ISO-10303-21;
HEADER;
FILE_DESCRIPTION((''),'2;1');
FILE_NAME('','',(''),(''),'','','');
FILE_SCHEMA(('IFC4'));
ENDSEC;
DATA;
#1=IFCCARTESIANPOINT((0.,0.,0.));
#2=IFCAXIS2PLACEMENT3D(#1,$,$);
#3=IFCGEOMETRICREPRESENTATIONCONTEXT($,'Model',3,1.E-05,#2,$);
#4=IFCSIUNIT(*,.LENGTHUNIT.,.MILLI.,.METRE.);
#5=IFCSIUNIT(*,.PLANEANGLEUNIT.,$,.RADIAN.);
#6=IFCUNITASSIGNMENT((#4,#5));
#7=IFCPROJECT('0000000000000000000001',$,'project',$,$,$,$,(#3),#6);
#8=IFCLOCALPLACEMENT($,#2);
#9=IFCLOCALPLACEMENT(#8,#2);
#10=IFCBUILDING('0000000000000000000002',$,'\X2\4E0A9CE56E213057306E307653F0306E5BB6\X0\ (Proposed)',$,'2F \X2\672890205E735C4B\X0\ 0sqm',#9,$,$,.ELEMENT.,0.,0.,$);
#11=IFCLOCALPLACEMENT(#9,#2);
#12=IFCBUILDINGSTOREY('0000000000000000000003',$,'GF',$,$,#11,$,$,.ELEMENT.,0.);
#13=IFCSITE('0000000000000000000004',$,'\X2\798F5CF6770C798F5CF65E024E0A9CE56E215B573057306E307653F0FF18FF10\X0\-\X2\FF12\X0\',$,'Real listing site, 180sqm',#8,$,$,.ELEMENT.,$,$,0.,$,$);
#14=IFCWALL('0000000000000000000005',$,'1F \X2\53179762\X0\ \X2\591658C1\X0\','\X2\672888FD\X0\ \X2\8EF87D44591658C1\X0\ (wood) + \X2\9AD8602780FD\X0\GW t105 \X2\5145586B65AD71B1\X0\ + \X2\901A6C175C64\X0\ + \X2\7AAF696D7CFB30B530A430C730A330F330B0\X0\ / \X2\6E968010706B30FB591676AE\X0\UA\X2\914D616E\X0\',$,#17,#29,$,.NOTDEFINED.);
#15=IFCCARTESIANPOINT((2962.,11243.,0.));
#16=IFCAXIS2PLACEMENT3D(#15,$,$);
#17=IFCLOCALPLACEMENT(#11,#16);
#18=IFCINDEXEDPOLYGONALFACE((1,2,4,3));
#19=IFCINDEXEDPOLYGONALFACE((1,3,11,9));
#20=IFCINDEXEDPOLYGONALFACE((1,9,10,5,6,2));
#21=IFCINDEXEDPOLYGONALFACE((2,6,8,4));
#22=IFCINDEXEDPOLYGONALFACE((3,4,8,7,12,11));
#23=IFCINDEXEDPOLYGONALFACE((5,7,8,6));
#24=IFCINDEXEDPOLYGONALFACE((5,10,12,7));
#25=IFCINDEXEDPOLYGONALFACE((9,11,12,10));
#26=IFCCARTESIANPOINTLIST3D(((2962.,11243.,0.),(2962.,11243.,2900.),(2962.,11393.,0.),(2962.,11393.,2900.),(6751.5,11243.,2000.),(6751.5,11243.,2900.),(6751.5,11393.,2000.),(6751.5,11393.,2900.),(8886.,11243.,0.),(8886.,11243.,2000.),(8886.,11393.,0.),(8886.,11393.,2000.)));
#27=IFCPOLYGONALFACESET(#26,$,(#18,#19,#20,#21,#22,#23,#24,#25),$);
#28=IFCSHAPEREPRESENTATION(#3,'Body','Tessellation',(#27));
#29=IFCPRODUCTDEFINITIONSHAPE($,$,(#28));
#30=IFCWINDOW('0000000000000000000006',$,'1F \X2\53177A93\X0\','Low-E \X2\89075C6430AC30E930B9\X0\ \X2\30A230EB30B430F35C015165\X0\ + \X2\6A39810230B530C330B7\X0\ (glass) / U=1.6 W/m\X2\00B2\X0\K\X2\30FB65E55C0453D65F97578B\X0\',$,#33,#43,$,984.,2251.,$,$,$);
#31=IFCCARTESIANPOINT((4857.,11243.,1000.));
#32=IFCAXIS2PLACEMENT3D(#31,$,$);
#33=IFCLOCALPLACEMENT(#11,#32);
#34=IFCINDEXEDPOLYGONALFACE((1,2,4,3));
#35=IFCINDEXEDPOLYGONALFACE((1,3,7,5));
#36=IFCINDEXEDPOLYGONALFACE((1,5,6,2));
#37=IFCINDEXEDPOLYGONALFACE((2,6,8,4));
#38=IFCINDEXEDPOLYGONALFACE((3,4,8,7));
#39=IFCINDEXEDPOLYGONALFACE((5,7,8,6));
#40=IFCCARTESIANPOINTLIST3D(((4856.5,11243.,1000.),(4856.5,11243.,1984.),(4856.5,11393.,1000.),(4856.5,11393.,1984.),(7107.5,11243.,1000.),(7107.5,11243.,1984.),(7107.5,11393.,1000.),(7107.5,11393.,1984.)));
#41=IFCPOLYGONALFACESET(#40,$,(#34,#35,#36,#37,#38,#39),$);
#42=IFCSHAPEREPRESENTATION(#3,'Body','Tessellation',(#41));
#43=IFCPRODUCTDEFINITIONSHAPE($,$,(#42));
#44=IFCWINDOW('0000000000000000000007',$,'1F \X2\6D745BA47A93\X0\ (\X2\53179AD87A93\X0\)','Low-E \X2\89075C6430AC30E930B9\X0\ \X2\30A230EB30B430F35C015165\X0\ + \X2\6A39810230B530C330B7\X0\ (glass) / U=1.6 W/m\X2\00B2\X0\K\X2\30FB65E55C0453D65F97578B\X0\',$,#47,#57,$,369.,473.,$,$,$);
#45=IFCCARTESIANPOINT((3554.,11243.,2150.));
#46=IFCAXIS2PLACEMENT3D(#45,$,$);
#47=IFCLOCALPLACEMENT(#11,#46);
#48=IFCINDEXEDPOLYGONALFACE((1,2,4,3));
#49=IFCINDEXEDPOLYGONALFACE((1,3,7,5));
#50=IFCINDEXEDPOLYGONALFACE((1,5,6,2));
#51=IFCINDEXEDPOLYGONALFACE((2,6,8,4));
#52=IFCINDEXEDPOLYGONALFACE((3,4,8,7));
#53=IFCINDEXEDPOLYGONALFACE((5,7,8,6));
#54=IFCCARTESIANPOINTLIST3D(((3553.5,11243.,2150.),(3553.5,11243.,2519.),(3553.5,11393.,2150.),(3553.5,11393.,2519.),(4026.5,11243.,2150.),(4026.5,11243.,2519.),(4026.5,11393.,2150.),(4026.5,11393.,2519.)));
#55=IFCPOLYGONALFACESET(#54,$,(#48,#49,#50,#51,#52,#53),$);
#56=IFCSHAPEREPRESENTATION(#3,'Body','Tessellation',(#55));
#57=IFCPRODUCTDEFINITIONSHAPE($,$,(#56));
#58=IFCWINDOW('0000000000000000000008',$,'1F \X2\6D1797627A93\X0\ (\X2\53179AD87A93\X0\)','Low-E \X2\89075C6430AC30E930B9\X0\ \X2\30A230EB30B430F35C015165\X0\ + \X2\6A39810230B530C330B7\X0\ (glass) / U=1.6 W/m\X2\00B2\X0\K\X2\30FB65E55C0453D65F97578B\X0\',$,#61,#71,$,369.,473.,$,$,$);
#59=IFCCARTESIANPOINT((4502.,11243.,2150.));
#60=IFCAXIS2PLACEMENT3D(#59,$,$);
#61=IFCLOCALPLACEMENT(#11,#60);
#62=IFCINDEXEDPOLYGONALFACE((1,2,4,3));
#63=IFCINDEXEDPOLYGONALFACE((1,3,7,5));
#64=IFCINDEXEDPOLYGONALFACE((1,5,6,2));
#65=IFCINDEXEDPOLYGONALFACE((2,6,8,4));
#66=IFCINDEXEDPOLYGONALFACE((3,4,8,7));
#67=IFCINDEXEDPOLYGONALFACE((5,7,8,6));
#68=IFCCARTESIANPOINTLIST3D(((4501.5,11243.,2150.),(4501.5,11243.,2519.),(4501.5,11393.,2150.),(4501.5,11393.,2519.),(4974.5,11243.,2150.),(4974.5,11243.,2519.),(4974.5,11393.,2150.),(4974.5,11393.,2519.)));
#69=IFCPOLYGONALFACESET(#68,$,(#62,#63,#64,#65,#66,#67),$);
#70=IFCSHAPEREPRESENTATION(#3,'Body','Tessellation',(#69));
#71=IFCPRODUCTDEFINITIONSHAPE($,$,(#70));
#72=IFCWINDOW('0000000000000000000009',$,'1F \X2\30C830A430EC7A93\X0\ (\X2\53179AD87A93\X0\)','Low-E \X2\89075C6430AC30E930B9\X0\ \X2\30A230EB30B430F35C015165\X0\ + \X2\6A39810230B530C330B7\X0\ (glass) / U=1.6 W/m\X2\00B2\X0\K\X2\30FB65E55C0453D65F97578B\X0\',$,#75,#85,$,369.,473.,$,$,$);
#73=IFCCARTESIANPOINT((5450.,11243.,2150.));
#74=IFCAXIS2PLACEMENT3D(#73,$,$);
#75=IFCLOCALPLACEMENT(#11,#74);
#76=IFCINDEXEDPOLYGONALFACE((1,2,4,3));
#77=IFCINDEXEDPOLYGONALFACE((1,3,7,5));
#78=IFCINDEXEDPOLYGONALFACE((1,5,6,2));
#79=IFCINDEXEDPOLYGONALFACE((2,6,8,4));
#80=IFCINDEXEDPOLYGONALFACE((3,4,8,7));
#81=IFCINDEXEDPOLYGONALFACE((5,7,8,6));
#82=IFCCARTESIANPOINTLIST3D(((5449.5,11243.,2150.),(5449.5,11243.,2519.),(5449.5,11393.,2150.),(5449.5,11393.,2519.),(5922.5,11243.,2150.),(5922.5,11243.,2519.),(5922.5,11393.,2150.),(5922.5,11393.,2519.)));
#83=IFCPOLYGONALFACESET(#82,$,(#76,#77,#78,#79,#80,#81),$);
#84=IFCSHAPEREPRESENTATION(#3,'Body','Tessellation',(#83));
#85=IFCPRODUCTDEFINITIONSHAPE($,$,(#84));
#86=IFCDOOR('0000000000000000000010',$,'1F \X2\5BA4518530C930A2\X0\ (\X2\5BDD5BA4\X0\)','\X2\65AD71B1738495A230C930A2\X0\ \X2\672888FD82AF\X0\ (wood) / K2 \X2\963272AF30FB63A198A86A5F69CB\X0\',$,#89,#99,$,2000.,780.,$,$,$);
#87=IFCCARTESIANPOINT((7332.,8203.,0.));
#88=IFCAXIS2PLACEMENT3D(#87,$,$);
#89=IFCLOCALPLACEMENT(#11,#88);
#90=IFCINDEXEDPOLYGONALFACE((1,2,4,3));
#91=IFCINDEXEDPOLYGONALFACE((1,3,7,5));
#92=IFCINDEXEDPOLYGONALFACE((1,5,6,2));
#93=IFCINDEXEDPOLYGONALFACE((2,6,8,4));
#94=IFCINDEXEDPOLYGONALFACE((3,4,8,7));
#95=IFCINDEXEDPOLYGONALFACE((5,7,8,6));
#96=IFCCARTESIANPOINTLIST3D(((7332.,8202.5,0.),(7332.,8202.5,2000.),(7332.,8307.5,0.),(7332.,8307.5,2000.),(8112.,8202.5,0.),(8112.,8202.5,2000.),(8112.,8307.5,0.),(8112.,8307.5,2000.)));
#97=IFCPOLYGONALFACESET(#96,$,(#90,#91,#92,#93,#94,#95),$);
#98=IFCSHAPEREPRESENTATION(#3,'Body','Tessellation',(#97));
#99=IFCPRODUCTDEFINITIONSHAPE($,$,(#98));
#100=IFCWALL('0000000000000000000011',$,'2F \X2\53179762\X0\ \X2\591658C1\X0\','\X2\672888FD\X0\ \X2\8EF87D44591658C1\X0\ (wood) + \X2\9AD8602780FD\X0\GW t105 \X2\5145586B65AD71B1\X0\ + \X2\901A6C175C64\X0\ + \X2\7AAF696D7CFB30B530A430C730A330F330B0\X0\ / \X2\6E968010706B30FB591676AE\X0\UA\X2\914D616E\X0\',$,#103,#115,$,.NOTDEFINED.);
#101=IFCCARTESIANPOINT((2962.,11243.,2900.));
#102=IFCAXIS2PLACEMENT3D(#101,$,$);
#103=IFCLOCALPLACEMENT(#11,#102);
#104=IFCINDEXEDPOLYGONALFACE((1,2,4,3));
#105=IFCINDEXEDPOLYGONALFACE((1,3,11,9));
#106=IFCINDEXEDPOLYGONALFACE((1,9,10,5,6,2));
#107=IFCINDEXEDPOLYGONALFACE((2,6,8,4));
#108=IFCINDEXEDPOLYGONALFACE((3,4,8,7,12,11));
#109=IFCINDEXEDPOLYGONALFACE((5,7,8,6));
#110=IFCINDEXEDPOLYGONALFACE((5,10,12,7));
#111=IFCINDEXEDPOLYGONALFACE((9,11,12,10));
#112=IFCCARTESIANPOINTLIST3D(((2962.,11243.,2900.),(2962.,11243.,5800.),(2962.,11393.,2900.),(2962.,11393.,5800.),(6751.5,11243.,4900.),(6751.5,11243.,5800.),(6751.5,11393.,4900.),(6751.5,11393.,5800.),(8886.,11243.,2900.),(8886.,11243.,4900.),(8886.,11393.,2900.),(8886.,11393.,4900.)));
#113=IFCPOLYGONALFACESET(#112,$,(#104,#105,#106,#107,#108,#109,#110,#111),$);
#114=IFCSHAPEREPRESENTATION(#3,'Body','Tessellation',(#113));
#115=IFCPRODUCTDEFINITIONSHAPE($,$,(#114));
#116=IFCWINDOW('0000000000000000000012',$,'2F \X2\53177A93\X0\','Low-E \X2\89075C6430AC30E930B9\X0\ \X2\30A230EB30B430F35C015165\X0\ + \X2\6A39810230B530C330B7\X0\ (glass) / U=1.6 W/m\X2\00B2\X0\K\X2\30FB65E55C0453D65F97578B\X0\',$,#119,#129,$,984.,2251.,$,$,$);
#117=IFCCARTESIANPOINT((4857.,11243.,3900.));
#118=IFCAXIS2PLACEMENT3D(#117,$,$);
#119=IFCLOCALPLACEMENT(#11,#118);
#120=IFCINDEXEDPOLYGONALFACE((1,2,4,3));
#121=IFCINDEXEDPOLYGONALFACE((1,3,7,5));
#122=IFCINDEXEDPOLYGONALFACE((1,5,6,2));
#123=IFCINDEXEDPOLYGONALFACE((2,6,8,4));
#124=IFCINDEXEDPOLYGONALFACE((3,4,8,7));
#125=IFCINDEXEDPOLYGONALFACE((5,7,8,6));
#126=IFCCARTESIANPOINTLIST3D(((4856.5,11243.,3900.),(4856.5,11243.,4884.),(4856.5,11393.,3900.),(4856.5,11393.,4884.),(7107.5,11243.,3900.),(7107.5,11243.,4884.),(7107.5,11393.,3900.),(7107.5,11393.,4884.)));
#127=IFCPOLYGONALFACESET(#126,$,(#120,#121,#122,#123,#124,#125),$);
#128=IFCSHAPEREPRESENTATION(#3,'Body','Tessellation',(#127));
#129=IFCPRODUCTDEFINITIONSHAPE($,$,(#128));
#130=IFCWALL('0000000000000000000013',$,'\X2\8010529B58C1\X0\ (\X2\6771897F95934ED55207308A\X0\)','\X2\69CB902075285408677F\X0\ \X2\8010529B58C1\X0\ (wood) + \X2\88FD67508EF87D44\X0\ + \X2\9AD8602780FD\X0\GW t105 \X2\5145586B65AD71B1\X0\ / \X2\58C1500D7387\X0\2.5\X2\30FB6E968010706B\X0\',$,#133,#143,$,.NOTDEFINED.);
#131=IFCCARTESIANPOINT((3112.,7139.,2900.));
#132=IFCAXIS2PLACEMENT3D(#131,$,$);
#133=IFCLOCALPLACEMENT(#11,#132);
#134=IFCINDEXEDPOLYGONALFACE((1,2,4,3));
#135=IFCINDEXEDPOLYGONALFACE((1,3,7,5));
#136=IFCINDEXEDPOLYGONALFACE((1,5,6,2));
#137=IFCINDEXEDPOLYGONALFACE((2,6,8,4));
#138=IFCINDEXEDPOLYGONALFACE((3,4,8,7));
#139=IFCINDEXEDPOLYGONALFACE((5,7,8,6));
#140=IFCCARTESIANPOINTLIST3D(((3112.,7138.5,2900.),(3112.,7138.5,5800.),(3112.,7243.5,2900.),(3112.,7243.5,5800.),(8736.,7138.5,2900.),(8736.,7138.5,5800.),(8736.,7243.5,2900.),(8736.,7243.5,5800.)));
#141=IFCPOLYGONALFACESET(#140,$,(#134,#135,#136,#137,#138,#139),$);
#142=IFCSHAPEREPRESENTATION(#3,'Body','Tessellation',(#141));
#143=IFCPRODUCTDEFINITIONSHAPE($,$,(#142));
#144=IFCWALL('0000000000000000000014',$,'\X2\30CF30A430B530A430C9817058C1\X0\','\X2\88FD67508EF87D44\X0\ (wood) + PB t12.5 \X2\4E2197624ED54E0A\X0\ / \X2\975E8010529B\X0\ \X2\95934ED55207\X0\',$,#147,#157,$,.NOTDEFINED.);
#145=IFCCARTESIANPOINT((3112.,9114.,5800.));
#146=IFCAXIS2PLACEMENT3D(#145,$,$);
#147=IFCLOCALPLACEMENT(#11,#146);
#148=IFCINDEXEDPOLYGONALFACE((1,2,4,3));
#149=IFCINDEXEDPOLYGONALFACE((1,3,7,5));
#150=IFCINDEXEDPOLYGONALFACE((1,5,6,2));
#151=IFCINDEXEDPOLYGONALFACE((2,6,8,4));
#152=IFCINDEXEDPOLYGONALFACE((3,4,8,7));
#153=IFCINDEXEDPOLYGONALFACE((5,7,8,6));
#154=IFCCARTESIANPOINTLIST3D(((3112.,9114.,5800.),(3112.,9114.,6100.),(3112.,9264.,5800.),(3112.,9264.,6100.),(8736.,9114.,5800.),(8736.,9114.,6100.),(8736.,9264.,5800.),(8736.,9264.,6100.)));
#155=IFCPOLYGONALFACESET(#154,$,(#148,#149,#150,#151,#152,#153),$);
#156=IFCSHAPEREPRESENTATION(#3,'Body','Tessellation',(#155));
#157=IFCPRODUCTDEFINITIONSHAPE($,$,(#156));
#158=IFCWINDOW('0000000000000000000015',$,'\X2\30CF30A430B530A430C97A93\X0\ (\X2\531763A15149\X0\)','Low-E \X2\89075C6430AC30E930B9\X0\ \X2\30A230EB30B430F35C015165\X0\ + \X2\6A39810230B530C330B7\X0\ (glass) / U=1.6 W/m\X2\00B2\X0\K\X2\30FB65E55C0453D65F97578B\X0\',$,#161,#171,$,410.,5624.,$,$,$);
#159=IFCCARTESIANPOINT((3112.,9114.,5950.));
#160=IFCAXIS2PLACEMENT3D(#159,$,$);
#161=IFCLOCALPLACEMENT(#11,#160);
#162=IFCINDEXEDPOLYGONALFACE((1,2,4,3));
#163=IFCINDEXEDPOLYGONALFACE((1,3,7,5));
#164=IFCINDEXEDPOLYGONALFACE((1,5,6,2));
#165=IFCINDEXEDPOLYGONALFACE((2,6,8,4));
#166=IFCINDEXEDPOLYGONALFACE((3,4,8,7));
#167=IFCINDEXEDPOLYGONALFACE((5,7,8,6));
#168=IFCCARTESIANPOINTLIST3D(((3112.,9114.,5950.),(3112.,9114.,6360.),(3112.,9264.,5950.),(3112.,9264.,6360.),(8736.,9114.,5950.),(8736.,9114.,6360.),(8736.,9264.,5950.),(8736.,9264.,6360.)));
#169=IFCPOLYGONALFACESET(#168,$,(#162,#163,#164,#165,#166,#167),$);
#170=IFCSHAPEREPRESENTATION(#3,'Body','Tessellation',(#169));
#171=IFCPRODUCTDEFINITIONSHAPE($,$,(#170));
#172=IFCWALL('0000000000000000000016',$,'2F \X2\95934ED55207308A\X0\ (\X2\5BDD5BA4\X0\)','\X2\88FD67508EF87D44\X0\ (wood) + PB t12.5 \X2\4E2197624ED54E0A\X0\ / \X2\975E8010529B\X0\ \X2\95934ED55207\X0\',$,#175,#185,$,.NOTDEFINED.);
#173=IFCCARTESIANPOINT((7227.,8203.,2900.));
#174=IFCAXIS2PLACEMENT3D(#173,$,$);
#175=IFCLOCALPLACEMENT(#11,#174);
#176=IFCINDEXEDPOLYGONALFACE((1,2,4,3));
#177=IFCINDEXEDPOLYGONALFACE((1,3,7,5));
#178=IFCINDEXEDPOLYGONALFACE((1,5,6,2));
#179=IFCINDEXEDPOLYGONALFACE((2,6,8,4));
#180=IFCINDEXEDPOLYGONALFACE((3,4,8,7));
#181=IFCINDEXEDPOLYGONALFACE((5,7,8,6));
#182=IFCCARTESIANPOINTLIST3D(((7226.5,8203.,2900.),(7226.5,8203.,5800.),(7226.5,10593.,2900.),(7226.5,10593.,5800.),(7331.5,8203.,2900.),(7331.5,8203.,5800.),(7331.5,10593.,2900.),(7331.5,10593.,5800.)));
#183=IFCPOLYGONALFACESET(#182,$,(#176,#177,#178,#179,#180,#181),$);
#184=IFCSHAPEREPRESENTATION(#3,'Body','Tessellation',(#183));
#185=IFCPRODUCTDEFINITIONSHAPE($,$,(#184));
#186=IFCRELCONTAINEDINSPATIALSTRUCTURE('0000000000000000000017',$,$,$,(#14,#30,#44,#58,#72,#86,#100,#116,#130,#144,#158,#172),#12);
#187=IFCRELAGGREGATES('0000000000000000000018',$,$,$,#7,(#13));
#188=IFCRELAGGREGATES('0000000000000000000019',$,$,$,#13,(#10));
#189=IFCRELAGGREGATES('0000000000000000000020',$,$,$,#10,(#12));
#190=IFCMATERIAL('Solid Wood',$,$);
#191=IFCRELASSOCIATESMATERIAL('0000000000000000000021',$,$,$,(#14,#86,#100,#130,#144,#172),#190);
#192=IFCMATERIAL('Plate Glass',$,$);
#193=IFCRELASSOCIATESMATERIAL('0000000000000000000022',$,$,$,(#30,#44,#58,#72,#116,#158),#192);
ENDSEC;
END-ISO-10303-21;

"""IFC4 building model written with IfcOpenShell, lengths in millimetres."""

from ifc_helpers import new_model, si_unit, frame, frame_2d, origin, place, context, project, spatial, rectangle, extrude, material, element, fill, save


model = new_model("IFC4")

# Units and contexts
model_context = context("Model", 3, precision=1e-05, world=origin())
ifc_project = project(units=[si_unit("LENGTHUNIT", "METRE", prefix="MILLI"), si_unit("PLANEANGLEUNIT", "RADIAN")], contexts=[model_context])

# Site, building, storey
site_placement = place(None, origin())
site = spatial("IfcSite", under=ifc_project, at=site_placement, Name="福島県福島市上鳥渡字しのぶ台８０-２", ObjectType="Real listing site, 180sqm", CompositionType="ELEMENT", RefElevation=0.0)
building_placement = place(site_placement, origin())
building = spatial("IfcBuilding", under=site, at=building_placement, Name="上鳥渡しのぶ台の家 (Proposed)", ObjectType="2F 木造平屋 0sqm", CompositionType="ELEMENT", ElevationOfRefHeight=0.0, ElevationOfTerrain=0.0)
storey_placement = place(building_placement, origin())
storey = spatial("IfcBuildingStorey", under=building, at=storey_placement, Name="GF", CompositionType="ELEMENT", Elevation=0.0)

# Wall, openings, windows
ifc_material_1 = material(Name="Solid Wood")
wall_1_placement = place(storey_placement, frame((2962.0, 11243.0, 0.0)))
wall_1 = element("IfcWall", 1, at=wall_1_placement, inside=storey, material=ifc_material_1, Name="1F 北面 外壁", Description="木製 軸組外壁 (wood) + 高性能GW t105 充填断熱 + 通気層 + 窯業系サイディング / 準耐火・外皮UA配慮", PredefinedType="NOTDEFINED", context=model_context, shape_type="SweptSolid", body=[
    extrude(rectangle(XDim=5924.0, YDim=150.0, at=frame_2d((2962.0, 75.0))), frame((2962.0, 11243.0, 0.0)), (0.0, 0.0, 1.0), 2900.0),
])
opening_1_placement = place(storey_placement, frame((4857.0, 11243.0, 1000.0)))
opening_1 = element("IfcOpeningElement", 2, at=opening_1_placement, cuts=wall_1, PredefinedType="NOTDEFINED", context=model_context, shape_type="SweptSolid", body=[
    extrude(rectangle(XDim=2251.0, YDim=150.0, at=frame_2d((1125.0, 75.0))), frame((4857.0, 11243.0, 1000.0)), (0.0, 0.0, 1.0), 984.0),
])
opening_2_placement = place(storey_placement, frame((3554.0, 11243.0, 2150.0)))
opening_2 = element("IfcOpeningElement", 3, at=opening_2_placement, cuts=wall_1, PredefinedType="NOTDEFINED", context=model_context, shape_type="SweptSolid", body=[
    extrude(rectangle(XDim=473.0, YDim=150.0, at=frame_2d((236.0, 75.0))), frame((3554.0, 11243.0, 2150.0)), (0.0, 0.0, 1.0), 369.0),
])
opening_3_placement = place(storey_placement, frame((4502.0, 11243.0, 2150.0)))
opening_3 = element("IfcOpeningElement", 4, at=opening_3_placement, cuts=wall_1, PredefinedType="NOTDEFINED", context=model_context, shape_type="SweptSolid", body=[
    extrude(rectangle(XDim=473.0, YDim=150.0, at=frame_2d((236.0, 75.0))), frame((4502.0, 11243.0, 2150.0)), (0.0, 0.0, 1.0), 369.0),
])
opening_4_placement = place(storey_placement, frame((5450.0, 11243.0, 2150.0)))
opening_4 = element("IfcOpeningElement", 5, at=opening_4_placement, cuts=wall_1, PredefinedType="NOTDEFINED", context=model_context, shape_type="SweptSolid", body=[
    extrude(rectangle(XDim=473.0, YDim=150.0, at=frame_2d((236.0, 75.0))), frame((5450.0, 11243.0, 2150.0)), (0.0, 0.0, 1.0), 369.0),
])
ifc_material_2 = material(Name="Plate Glass")
window_1_placement = place(storey_placement, frame((4857.0, 11243.0, 1000.0)))
window_1 = element("IfcWindow", 6, at=window_1_placement, inside=storey, material=ifc_material_2, Name="1F 北窓", Description="Low-E 複層ガラス アルゴン封入 + 樹脂サッシ (glass) / U=1.6 W/m²K・日射取得型", OverallHeight=984.0, OverallWidth=2251.0, context=model_context, shape_type="SweptSolid", body=[
    extrude(rectangle(XDim=2251.0, YDim=150.0, at=frame_2d((1125.0, 75.0))), frame((4857.0, 11243.0, 1000.0)), (0.0, 0.0, 1.0), 984.0),
])
fill(opening_1, window_1)
window_2_placement = place(storey_placement, frame((3554.0, 11243.0, 2150.0)))
window_2 = element("IfcWindow", 7, at=window_2_placement, inside=storey, material=ifc_material_2, Name="1F 浴室窓 (北高窓)", Description="Low-E 複層ガラス アルゴン封入 + 樹脂サッシ (glass) / U=1.6 W/m²K・日射取得型", OverallHeight=369.0, OverallWidth=473.0, context=model_context, shape_type="SweptSolid", body=[
    extrude(rectangle(XDim=473.0, YDim=150.0, at=frame_2d((236.0, 75.0))), frame((3554.0, 11243.0, 2150.0)), (0.0, 0.0, 1.0), 369.0),
])
fill(opening_2, window_2)
window_3_placement = place(storey_placement, frame((4502.0, 11243.0, 2150.0)))
window_3 = element("IfcWindow", 8, at=window_3_placement, inside=storey, material=ifc_material_2, Name="1F 洗面窓 (北高窓)", Description="Low-E 複層ガラス アルゴン封入 + 樹脂サッシ (glass) / U=1.6 W/m²K・日射取得型", OverallHeight=369.0, OverallWidth=473.0, context=model_context, shape_type="SweptSolid", body=[
    extrude(rectangle(XDim=473.0, YDim=150.0, at=frame_2d((236.0, 75.0))), frame((4502.0, 11243.0, 2150.0)), (0.0, 0.0, 1.0), 369.0),
])
fill(opening_3, window_3)
window_4_placement = place(storey_placement, frame((5450.0, 11243.0, 2150.0)))
window_4 = element("IfcWindow", 9, at=window_4_placement, inside=storey, material=ifc_material_2, Name="1F トイレ窓 (北高窓)", Description="Low-E 複層ガラス アルゴン封入 + 樹脂サッシ (glass) / U=1.6 W/m²K・日射取得型", OverallHeight=369.0, OverallWidth=473.0, context=model_context, shape_type="SweptSolid", body=[
    extrude(rectangle(XDim=473.0, YDim=150.0, at=frame_2d((236.0, 75.0))), frame((5450.0, 11243.0, 2150.0)), (0.0, 0.0, 1.0), 369.0),
])
fill(opening_4, window_4)

# Door
door_1_placement = place(storey_placement, frame((7332.0, 8203.0, 0.0)))
element("IfcDoor", 10, at=door_1_placement, inside=storey, material=ifc_material_1, Name="1F 室内ドア (寝室)", Description="断熱玄関ドア 木製芯 (wood) / K2 防犯・採風機構", OverallHeight=2000.0, OverallWidth=780.0, context=model_context, shape_type="SweptSolid", body=[
    extrude(rectangle(XDim=780.0, YDim=105.0, at=frame_2d((390.0, 52.0))), frame((7332.0, 8203.0, 0.0)), (0.0, 0.0, 1.0), 2000.0),
])

# Wall, opening, window
wall_2_placement = place(storey_placement, frame((2962.0, 11243.0, 2900.0)))
wall_2 = element("IfcWall", 11, at=wall_2_placement, inside=storey, material=ifc_material_1, Name="2F 北面 外壁", Description="木製 軸組外壁 (wood) + 高性能GW t105 充填断熱 + 通気層 + 窯業系サイディング / 準耐火・外皮UA配慮", PredefinedType="NOTDEFINED", context=model_context, shape_type="SweptSolid", body=[
    extrude(rectangle(XDim=5924.0, YDim=150.0, at=frame_2d((2962.0, 75.0))), frame((2962.0, 11243.0, 2900.0)), (0.0, 0.0, 1.0), 2900.0),
])
opening_5_placement = place(storey_placement, frame((4857.0, 11243.0, 3900.0)))
opening_5 = element("IfcOpeningElement", 12, at=opening_5_placement, cuts=wall_2, PredefinedType="NOTDEFINED", context=model_context, shape_type="SweptSolid", body=[
    extrude(rectangle(XDim=2251.0, YDim=150.0, at=frame_2d((1125.0, 75.0))), frame((4857.0, 11243.0, 3900.0)), (0.0, 0.0, 1.0), 984.0),
])
window_5_placement = place(storey_placement, frame((4857.0, 11243.0, 3900.0)))
window_5 = element("IfcWindow", 13, at=window_5_placement, inside=storey, material=ifc_material_2, Name="2F 北窓", Description="Low-E 複層ガラス アルゴン封入 + 樹脂サッシ (glass) / U=1.6 W/m²K・日射取得型", OverallHeight=984.0, OverallWidth=2251.0, context=model_context, shape_type="SweptSolid", body=[
    extrude(rectangle(XDim=2251.0, YDim=150.0, at=frame_2d((1125.0, 75.0))), frame((4857.0, 11243.0, 3900.0)), (0.0, 0.0, 1.0), 984.0),
])
fill(opening_5, window_5)

# Wall
wall_3_placement = place(storey_placement, frame((3112.0, 7139.0, 2900.0)))
element("IfcWall", 14, at=wall_3_placement, inside=storey, material=ifc_material_1, Name="耐力壁 (東西間仕切り)", Description="構造用合板 耐力壁 (wood) + 製材軸組 + 高性能GW t105 充填断熱 / 壁倍率2.5・準耐火", PredefinedType="NOTDEFINED", context=model_context, shape_type="SweptSolid", body=[
    extrude(rectangle(XDim=5624.0, YDim=105.0, at=frame_2d((2812.0, 52.0))), frame((3112.0, 7139.0, 2900.0)), (0.0, 0.0, 1.0), 2900.0),
])

# Wall, opening, window
wall_4_placement = place(storey_placement, frame((3112.0, 9114.0, 5800.0)))
wall_4 = element("IfcWall", 15, at=wall_4_placement, inside=storey, material=ifc_material_1, Name="ハイサイド腰壁", Description="製材軸組 (wood) + PB t12.5 両面仕上 / 非耐力 間仕切", PredefinedType="NOTDEFINED", context=model_context, shape_type="SweptSolid", body=[
    extrude(rectangle(XDim=5624.0, YDim=150.0, at=frame_2d((2812.0, 75.0))), frame((3112.0, 9114.0, 5800.0)), (0.0, 0.0, 1.0), 700.0),
])
opening_6_placement = place(storey_placement, frame((3112.0, 9114.0, 5950.0)))
opening_6 = element("IfcOpeningElement", 16, at=opening_6_placement, cuts=wall_4, PredefinedType="NOTDEFINED", context=model_context, shape_type="SweptSolid", body=[
    extrude(rectangle(XDim=5624.0, YDim=150.0, at=frame_2d((2812.0, 75.0))), frame((3112.0, 9114.0, 5950.0)), (0.0, 0.0, 1.0), 410.0),
])
window_6_placement = place(storey_placement, frame((3112.0, 9114.0, 5950.0)))
window_6 = element("IfcWindow", 17, at=window_6_placement, inside=storey, material=ifc_material_2, Name="ハイサイド窓 (北採光)", Description="Low-E 複層ガラス アルゴン封入 + 樹脂サッシ (glass) / U=1.6 W/m²K・日射取得型", OverallHeight=410.0, OverallWidth=5624.0, context=model_context, shape_type="SweptSolid", body=[
    extrude(rectangle(XDim=5624.0, YDim=150.0, at=frame_2d((2812.0, 75.0))), frame((3112.0, 9114.0, 5950.0)), (0.0, 0.0, 1.0), 410.0),
])
fill(opening_6, window_6)

# Wall
wall_5_placement = place(storey_placement, frame((7227.0, 8203.0, 2900.0)))
element("IfcWall", 18, at=wall_5_placement, inside=storey, material=ifc_material_1, Name="2F 間仕切り (寝室)", Description="製材軸組 (wood) + PB t12.5 両面仕上 / 非耐力 間仕切", PredefinedType="NOTDEFINED", context=model_context, shape_type="SweptSolid", body=[
    extrude(rectangle(XDim=105.0, YDim=2390.0, at=frame_2d((52.0, 1195.0))), frame((7227.0, 8203.0, 2900.0)), (0.0, 0.0, 1.0), 2900.0),
])

save(model, "model.ifc")
